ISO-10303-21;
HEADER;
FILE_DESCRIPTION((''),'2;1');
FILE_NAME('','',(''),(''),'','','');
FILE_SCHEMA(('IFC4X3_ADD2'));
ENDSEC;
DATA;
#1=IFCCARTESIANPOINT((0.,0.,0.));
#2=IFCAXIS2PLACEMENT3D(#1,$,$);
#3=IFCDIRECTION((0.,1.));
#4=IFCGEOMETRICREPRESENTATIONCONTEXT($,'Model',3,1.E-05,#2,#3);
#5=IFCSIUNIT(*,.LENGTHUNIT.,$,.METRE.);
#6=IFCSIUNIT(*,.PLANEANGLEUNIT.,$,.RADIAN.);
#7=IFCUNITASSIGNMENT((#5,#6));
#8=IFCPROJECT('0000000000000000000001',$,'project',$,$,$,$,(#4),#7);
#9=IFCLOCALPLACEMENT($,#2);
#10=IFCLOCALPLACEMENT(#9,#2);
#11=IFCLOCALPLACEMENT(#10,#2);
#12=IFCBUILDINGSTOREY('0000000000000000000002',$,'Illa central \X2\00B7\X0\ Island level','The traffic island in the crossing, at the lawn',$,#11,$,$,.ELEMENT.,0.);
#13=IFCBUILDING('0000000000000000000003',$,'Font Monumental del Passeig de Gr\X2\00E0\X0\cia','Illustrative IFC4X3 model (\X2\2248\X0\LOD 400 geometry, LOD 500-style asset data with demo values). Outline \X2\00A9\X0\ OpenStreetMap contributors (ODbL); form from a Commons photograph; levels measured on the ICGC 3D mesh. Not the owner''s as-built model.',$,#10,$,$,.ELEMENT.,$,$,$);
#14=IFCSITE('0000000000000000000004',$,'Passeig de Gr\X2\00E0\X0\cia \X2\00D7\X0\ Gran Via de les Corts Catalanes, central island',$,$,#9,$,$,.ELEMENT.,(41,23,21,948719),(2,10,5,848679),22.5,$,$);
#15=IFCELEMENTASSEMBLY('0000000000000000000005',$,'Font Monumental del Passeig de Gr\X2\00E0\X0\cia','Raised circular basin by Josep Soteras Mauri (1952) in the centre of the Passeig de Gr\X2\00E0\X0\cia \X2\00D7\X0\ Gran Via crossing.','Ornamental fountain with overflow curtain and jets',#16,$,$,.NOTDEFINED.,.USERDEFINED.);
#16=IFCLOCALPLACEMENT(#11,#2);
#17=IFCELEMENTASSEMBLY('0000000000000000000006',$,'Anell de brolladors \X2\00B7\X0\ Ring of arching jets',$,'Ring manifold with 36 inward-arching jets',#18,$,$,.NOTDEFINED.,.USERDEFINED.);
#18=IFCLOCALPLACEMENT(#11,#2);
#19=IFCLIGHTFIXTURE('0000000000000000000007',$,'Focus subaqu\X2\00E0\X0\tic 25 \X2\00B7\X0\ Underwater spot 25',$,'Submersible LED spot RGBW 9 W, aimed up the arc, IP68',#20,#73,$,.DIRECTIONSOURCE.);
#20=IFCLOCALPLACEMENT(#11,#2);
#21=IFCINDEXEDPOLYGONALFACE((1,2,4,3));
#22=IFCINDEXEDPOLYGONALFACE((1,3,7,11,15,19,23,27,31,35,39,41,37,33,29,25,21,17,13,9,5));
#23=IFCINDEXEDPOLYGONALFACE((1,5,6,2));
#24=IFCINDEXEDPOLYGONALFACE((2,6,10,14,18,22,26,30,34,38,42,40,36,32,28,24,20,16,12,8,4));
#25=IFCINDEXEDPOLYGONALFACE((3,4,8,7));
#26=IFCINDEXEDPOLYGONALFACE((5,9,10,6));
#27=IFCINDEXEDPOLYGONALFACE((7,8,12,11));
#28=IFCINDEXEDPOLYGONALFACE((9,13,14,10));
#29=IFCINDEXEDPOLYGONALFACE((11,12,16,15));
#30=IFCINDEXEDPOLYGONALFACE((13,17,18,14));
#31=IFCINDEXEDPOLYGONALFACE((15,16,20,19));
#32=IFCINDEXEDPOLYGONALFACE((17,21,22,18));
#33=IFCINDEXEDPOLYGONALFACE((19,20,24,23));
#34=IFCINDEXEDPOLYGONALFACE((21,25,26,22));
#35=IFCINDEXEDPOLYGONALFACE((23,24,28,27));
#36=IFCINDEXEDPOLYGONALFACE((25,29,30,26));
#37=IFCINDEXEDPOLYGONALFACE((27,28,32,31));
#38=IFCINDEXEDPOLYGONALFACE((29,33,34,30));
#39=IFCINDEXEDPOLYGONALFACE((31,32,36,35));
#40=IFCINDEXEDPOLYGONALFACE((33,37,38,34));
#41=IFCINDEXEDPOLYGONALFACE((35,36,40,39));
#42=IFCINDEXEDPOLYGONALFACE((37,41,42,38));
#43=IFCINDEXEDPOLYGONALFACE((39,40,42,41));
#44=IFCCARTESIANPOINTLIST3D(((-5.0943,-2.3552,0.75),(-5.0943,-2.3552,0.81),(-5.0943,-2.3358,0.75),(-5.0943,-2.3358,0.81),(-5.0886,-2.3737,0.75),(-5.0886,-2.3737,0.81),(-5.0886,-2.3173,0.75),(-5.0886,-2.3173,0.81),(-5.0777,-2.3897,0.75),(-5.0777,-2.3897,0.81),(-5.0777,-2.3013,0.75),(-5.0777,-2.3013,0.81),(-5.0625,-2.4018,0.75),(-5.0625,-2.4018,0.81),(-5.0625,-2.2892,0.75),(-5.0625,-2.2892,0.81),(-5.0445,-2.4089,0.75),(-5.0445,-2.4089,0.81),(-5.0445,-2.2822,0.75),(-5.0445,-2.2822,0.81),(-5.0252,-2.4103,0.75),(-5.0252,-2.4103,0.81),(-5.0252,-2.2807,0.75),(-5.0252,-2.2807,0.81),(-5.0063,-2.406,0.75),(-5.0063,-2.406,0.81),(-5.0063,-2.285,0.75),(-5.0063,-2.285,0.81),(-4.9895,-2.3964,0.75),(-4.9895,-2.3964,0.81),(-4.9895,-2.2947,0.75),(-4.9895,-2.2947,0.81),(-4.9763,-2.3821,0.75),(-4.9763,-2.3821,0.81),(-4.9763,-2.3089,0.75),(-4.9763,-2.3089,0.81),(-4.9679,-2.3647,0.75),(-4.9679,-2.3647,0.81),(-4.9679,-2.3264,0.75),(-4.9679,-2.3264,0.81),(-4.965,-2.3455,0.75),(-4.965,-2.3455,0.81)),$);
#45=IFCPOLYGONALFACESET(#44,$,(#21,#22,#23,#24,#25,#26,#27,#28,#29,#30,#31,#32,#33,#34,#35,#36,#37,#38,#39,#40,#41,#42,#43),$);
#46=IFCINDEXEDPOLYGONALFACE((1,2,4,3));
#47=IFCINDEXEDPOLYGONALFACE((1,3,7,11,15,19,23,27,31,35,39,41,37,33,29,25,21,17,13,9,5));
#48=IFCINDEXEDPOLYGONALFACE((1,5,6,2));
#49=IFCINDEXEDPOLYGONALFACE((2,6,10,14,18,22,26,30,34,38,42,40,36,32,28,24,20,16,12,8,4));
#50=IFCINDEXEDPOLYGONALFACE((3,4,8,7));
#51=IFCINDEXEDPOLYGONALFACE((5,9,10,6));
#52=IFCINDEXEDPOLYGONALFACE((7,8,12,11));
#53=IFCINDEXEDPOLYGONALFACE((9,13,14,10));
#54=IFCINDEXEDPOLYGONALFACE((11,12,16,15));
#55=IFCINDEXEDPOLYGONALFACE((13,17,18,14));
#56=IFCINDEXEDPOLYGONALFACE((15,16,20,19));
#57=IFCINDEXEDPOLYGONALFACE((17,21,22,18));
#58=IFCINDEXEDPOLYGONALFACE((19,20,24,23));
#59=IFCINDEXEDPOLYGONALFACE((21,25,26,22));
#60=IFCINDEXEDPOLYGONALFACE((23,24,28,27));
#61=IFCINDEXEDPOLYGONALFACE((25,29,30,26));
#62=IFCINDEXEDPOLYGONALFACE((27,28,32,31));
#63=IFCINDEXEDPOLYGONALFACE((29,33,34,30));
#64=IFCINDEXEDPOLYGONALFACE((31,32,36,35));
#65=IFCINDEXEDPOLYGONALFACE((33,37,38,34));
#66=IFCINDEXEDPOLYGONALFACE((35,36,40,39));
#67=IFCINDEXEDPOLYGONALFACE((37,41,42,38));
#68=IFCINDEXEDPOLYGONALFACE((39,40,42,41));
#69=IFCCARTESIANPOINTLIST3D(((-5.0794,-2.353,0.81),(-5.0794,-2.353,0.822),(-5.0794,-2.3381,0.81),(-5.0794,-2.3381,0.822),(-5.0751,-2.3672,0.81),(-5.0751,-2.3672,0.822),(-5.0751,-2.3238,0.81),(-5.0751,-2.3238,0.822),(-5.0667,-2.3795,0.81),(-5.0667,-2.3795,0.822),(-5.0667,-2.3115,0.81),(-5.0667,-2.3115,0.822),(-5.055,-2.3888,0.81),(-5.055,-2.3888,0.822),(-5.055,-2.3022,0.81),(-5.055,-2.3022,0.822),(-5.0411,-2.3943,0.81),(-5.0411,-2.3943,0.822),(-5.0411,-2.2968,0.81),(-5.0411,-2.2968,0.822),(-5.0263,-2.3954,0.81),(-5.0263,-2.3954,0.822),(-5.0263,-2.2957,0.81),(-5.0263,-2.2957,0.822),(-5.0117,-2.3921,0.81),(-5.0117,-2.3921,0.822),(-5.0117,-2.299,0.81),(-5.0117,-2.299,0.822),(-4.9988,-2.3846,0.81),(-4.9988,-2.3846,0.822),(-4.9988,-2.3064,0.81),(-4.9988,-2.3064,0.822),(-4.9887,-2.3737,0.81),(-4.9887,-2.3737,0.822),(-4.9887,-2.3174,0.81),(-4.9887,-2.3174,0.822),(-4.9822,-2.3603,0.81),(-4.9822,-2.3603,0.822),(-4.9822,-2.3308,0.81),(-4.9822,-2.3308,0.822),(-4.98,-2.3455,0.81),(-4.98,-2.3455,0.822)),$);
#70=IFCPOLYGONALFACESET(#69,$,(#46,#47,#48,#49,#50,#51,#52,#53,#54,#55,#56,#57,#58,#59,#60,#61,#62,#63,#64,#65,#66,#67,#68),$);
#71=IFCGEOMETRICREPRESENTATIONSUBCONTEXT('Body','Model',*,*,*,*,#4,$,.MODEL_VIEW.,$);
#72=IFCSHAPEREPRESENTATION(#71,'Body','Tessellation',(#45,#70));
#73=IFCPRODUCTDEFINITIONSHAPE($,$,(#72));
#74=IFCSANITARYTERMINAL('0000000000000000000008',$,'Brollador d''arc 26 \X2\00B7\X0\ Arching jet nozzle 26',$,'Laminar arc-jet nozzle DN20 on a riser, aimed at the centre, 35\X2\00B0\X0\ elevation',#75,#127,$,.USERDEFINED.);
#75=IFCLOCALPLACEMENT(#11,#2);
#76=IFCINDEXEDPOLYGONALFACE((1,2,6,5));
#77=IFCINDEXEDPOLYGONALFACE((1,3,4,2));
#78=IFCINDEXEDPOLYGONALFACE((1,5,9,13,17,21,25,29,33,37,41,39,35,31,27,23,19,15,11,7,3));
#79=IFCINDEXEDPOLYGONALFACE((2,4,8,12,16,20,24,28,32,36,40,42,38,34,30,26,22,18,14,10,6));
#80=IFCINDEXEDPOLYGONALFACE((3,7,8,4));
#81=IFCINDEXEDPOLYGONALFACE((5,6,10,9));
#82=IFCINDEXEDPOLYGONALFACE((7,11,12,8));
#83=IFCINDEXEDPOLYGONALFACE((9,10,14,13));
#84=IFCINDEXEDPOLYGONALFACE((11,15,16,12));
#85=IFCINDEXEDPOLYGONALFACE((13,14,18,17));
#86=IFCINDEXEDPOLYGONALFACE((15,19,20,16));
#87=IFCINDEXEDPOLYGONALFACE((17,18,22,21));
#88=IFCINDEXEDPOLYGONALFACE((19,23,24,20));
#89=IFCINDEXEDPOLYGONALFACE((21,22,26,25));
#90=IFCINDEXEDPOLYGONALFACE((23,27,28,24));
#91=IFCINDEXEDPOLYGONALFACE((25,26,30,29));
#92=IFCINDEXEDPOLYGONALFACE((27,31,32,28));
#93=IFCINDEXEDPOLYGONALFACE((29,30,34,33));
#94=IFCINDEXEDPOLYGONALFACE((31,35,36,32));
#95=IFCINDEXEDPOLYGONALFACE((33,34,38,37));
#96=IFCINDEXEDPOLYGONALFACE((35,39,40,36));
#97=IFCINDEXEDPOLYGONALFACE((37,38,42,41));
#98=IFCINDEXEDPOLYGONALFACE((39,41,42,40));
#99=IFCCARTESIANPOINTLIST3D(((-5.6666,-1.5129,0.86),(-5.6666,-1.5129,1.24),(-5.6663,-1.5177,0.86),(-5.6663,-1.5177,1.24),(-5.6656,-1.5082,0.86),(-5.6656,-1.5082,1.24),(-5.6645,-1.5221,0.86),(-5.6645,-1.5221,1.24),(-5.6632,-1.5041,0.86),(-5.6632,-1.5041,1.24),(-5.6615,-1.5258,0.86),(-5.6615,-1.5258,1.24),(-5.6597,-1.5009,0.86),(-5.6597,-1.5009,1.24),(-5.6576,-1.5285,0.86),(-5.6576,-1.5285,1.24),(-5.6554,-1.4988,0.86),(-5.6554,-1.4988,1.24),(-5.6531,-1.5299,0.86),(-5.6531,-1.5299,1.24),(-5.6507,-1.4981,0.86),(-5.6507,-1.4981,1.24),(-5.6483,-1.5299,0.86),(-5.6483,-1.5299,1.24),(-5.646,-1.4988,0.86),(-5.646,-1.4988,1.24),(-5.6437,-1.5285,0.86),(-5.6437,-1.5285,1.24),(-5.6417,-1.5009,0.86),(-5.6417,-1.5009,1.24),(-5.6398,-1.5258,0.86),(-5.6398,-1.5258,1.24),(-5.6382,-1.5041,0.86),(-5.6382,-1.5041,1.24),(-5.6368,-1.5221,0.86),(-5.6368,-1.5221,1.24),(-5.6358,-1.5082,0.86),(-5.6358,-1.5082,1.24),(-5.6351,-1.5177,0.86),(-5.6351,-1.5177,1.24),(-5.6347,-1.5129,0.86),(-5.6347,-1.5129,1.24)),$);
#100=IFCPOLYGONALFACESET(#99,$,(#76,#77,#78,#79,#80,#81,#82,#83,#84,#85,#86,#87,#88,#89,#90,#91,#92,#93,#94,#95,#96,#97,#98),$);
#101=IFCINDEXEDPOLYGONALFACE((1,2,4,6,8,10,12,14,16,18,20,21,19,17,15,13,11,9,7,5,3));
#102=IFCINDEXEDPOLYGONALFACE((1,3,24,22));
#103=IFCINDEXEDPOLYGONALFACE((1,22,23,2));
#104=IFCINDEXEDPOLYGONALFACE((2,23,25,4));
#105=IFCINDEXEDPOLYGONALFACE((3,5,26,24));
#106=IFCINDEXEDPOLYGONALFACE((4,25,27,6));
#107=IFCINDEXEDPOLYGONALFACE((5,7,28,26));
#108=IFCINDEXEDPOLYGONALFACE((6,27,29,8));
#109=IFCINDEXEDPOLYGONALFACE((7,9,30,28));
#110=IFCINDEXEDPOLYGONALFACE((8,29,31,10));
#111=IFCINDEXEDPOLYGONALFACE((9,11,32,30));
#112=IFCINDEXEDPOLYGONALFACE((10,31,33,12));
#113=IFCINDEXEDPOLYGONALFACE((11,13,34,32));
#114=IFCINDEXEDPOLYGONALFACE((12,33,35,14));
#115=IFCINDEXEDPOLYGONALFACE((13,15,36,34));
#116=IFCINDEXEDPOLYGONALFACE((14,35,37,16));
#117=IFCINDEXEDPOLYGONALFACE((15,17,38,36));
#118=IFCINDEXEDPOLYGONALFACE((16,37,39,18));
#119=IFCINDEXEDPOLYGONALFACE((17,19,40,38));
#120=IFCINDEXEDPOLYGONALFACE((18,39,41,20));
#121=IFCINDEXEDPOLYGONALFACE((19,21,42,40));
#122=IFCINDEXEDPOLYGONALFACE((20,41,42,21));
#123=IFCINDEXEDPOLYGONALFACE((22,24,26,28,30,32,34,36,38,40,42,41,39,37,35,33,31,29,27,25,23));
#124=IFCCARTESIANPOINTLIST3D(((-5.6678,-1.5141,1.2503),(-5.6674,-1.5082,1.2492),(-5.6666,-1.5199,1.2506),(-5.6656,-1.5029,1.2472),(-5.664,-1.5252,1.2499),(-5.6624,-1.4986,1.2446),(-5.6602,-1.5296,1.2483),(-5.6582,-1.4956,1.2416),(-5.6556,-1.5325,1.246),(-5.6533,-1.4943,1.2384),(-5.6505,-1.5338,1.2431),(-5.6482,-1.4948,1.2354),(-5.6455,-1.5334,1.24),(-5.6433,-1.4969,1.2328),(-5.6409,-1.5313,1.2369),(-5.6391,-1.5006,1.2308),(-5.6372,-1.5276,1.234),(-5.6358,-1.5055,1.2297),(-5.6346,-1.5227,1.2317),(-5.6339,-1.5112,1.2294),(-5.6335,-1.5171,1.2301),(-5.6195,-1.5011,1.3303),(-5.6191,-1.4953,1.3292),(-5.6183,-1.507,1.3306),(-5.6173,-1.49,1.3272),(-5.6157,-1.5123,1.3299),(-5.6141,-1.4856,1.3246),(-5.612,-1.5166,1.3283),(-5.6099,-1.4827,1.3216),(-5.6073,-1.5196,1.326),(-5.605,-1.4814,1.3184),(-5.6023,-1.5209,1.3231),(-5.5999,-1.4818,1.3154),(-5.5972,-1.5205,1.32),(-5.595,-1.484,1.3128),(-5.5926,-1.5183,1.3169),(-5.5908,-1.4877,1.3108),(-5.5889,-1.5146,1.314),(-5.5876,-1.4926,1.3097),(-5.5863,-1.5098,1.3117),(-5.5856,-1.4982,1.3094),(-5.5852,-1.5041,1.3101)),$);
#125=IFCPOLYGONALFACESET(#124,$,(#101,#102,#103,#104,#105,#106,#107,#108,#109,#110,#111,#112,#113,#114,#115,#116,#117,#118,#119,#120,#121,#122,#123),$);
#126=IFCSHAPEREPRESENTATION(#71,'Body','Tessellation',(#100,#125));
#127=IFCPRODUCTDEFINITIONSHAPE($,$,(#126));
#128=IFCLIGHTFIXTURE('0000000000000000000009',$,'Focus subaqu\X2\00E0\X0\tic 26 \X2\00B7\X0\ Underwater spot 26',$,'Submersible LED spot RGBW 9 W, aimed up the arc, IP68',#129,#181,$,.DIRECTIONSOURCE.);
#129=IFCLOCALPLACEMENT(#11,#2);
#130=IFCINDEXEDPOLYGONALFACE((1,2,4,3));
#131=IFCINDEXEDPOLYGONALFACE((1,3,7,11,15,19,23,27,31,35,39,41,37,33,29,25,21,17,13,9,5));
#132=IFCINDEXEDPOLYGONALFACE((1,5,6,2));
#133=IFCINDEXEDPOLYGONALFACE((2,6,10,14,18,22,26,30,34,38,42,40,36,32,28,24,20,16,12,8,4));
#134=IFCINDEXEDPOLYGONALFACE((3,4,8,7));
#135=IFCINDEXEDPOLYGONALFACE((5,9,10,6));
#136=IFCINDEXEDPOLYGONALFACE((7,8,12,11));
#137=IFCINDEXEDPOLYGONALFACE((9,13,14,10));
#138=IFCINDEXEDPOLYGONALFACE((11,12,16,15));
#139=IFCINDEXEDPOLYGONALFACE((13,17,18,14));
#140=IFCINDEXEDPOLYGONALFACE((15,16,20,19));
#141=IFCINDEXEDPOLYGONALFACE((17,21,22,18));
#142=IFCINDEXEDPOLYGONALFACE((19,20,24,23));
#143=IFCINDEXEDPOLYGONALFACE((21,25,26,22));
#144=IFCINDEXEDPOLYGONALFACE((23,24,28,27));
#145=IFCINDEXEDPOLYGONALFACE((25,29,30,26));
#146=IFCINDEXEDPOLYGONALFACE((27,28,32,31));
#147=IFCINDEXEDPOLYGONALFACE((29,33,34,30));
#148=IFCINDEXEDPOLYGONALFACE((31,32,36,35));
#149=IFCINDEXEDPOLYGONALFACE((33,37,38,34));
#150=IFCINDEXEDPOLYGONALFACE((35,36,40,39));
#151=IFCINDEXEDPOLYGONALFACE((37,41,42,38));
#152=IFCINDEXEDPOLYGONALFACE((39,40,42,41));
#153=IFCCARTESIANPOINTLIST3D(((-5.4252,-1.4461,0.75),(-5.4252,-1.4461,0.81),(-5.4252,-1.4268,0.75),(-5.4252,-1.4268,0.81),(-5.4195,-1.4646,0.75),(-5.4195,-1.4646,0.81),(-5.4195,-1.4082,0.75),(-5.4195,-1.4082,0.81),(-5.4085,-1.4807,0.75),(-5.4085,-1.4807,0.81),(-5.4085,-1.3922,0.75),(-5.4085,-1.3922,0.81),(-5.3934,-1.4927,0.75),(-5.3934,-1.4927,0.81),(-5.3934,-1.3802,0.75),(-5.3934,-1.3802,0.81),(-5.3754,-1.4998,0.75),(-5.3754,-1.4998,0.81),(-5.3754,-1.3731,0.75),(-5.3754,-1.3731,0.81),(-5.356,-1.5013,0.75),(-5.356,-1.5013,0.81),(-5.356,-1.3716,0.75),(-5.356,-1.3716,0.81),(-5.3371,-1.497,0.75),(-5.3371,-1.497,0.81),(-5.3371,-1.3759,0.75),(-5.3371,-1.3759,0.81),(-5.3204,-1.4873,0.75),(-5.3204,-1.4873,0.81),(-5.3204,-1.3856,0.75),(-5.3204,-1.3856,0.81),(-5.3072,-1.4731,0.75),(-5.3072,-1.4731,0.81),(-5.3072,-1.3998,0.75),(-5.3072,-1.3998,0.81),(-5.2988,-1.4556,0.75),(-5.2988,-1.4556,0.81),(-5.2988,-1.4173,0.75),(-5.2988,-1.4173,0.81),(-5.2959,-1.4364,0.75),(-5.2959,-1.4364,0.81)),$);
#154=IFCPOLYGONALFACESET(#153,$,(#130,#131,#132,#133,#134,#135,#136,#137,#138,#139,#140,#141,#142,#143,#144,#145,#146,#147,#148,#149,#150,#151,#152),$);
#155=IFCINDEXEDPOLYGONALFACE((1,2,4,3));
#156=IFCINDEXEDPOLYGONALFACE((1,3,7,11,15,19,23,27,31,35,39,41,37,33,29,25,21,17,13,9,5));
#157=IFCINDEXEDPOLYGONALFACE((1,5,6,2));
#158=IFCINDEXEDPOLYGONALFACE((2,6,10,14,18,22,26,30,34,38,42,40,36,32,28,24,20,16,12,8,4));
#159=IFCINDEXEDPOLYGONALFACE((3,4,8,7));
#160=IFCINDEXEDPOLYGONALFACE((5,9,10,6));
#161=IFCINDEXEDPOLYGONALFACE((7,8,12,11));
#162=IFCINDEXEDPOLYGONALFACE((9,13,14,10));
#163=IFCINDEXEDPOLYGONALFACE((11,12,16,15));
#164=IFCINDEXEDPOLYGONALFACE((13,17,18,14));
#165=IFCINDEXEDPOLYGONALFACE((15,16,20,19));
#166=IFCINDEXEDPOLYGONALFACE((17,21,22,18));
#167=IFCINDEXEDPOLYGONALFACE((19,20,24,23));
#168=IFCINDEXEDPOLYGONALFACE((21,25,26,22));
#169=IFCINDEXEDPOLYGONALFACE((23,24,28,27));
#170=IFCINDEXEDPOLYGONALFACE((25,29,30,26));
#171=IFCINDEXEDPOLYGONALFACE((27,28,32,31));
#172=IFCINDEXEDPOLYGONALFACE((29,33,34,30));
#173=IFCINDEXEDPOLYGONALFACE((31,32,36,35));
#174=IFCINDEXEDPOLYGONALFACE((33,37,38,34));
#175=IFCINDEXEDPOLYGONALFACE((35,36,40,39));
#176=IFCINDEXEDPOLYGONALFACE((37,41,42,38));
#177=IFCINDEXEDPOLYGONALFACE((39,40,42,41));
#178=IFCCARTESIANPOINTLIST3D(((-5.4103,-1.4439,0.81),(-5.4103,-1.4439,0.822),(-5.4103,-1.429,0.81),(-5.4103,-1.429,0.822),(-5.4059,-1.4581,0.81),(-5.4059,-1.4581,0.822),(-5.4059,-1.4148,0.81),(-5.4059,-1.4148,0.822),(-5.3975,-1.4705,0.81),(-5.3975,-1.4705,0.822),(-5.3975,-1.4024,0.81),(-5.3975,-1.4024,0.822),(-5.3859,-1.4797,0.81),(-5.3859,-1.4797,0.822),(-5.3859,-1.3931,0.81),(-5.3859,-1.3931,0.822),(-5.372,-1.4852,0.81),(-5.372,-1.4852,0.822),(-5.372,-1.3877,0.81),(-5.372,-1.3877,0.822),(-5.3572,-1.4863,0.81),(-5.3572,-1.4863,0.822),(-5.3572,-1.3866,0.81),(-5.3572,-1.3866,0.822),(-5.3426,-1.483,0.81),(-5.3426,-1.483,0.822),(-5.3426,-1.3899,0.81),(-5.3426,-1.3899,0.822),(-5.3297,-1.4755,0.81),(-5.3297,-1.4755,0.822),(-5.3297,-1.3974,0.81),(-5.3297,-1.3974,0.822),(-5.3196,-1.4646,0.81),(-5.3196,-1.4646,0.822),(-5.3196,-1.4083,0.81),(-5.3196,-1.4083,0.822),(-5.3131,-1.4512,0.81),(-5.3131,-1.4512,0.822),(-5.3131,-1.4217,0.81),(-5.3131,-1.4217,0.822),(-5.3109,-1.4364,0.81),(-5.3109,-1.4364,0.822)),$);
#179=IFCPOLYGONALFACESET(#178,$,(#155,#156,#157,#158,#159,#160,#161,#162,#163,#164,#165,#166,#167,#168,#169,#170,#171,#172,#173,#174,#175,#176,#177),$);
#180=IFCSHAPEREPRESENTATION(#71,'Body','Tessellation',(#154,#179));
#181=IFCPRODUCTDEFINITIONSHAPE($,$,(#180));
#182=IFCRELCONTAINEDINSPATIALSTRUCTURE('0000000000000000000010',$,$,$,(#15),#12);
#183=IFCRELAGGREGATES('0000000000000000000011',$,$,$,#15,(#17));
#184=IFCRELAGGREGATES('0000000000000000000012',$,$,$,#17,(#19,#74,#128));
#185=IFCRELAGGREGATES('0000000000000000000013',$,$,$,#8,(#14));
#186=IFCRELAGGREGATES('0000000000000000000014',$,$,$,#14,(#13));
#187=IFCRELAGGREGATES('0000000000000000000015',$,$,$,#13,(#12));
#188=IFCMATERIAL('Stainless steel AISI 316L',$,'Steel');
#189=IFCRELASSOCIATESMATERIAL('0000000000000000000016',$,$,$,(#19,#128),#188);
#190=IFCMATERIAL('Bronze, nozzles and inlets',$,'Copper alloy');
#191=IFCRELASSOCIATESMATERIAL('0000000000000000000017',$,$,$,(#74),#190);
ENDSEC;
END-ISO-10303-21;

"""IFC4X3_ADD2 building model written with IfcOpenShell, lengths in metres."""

from ifc_helpers import new_model, si_unit, direction, frame, origin, origin_2d_with_axis, place, context, subcontext, project, spatial, circle, extrude, material, element, aggregate, save


model = new_model("IFC4X3_ADD2")

# Units and contexts
model_context = context("Model", 3, precision=1e-05, world=origin(), true_north=direction((0.0, 1.0)))
body_context = subcontext(model_context, "Body", "Model", "MODEL_VIEW")
ifc_project = project(units=[si_unit("LENGTHUNIT", "METRE"), si_unit("PLANEANGLEUNIT", "RADIAN")], contexts=[model_context])

# Site, building, storey
site_placement = place(None, origin())
site = spatial("IfcSite", under=ifc_project, at=site_placement, Name="Passeig de Gràcia × Gran Via de les Corts Catalanes, central island", CompositionType="ELEMENT", RefLatitude=(41, 23, 21, 948719), RefLongitude=(2, 10, 5, 848679), RefElevation=22.5)
building_placement = place(site_placement, origin())
building = spatial("IfcBuilding", under=site, at=building_placement, Name="Font Monumental del Passeig de Gràcia", Description="Illustrative IFC4X3 model (≈LOD 400 geometry, LOD 500-style asset data with demo values). Outline © OpenStreetMap contributors (ODbL); form from a Commons photograph; levels measured on the ICGC 3D mesh. Not the owner's as-built model.", CompositionType="ELEMENT")
storey_placement = place(building_placement, origin())
storey = spatial("IfcBuildingStorey", under=building, at=storey_placement, Name="Illa central · Island level", Description="The traffic island in the crossing, at the lawn", CompositionType="ELEMENT", Elevation=0.0)

# Element assemblies, light fixtures, sanitary terminal
assembly_1_placement = place(building_placement, origin())
assembly_1 = element("IfcElementAssembly", 1, at=assembly_1_placement, inside=storey, Name="Font Monumental del Passeig de Gràcia", Description="Raised circular basin by Josep Soteras Mauri (1952) in the centre of the Passeig de Gràcia × Gran Via crossing.", ObjectType="Ornamental fountain with overflow curtain and jets", AssemblyPlace="NOTDEFINED", PredefinedType="USERDEFINED")
assembly_2_placement = place(building_placement, origin())
assembly_2 = element("IfcElementAssembly", 2, at=assembly_2_placement, Name="Anell de brolladors · Ring of arching jets", ObjectType="Ring manifold with 36 inward-arching jets", AssemblyPlace="NOTDEFINED", PredefinedType="USERDEFINED")
aggregate(assembly_1, [assembly_2])
ifc_material_1 = material(Name="Stainless steel AISI 316L", Category="Steel")
ifc_material_2 = material(Name="Bronze, nozzles and inlets", Category="Copper alloy")
light_fixture_1_placement = place(building_placement, origin())
light_fixture_1 = element("IfcLightFixture", 3, at=light_fixture_1_placement, material=ifc_material_1, Name="Focus subaquàtic 25 · Underwater spot 25", ObjectType="Submersible LED spot RGBW 9 W, aimed up the arc, IP68", PredefinedType="DIRECTIONSOURCE", context=body_context, shape_type="SweptSolid", body=[
    extrude(circle(Radius=0.065, at=origin_2d_with_axis()), frame((-5.03, -2.3455, 0.75)), (0.0, 0.0, 1.0), 0.06),
    extrude(circle(Radius=0.05, at=origin_2d_with_axis()), frame((-5.03, -2.3455, 0.81)), (0.0, 0.0, 1.0), 0.012),
])
sanitary_terminal_1_placement = place(building_placement, origin())
sanitary_terminal_1 = element("IfcSanitaryTerminal", 4, at=sanitary_terminal_1_placement, material=ifc_material_2, Name="Brollador d'arc 26 · Arching jet nozzle 26", ObjectType="Laminar arc-jet nozzle DN20 on a riser, aimed at the centre, 35° elevation", PredefinedType="USERDEFINED", context=body_context, shape_type="SweptSolid", body=[
    extrude(circle(Radius=0.016, at=origin_2d_with_axis()), frame((-5.6507, -1.5141, 0.86), z_axis=(0.0, 0.0, 1.0), x_axis=(0.0, 1.0, 0.0)), (0.0, 0.0, 1.0), 0.38),
    extrude(circle(Radius=0.02, at=origin_2d_with_axis()), frame((-5.6507, -1.5141, 1.24), z_axis=(0.51194, 0.137174, 0.847998), x_axis=(0.258819, -0.965926, 0.0)), (0.0, 0.0, 1.0), 0.0943),
])
light_fixture_2_placement = place(building_placement, origin())
light_fixture_2 = element("IfcLightFixture", 5, at=light_fixture_2_placement, material=ifc_material_1, Name="Focus subaquàtic 26 · Underwater spot 26", ObjectType="Submersible LED spot RGBW 9 W, aimed up the arc, IP68", PredefinedType="DIRECTIONSOURCE", context=body_context, shape_type="SweptSolid", body=[
    extrude(circle(Radius=0.065, at=origin_2d_with_axis()), frame((-5.3609, -1.4364, 0.75)), (0.0, 0.0, 1.0), 0.06),
    extrude(circle(Radius=0.05, at=origin_2d_with_axis()), frame((-5.3609, -1.4364, 0.81)), (0.0, 0.0, 1.0), 0.012),
])
aggregate(assembly_2, [light_fixture_1, sanitary_terminal_1, light_fixture_2])

save(model, "model.ifc")
